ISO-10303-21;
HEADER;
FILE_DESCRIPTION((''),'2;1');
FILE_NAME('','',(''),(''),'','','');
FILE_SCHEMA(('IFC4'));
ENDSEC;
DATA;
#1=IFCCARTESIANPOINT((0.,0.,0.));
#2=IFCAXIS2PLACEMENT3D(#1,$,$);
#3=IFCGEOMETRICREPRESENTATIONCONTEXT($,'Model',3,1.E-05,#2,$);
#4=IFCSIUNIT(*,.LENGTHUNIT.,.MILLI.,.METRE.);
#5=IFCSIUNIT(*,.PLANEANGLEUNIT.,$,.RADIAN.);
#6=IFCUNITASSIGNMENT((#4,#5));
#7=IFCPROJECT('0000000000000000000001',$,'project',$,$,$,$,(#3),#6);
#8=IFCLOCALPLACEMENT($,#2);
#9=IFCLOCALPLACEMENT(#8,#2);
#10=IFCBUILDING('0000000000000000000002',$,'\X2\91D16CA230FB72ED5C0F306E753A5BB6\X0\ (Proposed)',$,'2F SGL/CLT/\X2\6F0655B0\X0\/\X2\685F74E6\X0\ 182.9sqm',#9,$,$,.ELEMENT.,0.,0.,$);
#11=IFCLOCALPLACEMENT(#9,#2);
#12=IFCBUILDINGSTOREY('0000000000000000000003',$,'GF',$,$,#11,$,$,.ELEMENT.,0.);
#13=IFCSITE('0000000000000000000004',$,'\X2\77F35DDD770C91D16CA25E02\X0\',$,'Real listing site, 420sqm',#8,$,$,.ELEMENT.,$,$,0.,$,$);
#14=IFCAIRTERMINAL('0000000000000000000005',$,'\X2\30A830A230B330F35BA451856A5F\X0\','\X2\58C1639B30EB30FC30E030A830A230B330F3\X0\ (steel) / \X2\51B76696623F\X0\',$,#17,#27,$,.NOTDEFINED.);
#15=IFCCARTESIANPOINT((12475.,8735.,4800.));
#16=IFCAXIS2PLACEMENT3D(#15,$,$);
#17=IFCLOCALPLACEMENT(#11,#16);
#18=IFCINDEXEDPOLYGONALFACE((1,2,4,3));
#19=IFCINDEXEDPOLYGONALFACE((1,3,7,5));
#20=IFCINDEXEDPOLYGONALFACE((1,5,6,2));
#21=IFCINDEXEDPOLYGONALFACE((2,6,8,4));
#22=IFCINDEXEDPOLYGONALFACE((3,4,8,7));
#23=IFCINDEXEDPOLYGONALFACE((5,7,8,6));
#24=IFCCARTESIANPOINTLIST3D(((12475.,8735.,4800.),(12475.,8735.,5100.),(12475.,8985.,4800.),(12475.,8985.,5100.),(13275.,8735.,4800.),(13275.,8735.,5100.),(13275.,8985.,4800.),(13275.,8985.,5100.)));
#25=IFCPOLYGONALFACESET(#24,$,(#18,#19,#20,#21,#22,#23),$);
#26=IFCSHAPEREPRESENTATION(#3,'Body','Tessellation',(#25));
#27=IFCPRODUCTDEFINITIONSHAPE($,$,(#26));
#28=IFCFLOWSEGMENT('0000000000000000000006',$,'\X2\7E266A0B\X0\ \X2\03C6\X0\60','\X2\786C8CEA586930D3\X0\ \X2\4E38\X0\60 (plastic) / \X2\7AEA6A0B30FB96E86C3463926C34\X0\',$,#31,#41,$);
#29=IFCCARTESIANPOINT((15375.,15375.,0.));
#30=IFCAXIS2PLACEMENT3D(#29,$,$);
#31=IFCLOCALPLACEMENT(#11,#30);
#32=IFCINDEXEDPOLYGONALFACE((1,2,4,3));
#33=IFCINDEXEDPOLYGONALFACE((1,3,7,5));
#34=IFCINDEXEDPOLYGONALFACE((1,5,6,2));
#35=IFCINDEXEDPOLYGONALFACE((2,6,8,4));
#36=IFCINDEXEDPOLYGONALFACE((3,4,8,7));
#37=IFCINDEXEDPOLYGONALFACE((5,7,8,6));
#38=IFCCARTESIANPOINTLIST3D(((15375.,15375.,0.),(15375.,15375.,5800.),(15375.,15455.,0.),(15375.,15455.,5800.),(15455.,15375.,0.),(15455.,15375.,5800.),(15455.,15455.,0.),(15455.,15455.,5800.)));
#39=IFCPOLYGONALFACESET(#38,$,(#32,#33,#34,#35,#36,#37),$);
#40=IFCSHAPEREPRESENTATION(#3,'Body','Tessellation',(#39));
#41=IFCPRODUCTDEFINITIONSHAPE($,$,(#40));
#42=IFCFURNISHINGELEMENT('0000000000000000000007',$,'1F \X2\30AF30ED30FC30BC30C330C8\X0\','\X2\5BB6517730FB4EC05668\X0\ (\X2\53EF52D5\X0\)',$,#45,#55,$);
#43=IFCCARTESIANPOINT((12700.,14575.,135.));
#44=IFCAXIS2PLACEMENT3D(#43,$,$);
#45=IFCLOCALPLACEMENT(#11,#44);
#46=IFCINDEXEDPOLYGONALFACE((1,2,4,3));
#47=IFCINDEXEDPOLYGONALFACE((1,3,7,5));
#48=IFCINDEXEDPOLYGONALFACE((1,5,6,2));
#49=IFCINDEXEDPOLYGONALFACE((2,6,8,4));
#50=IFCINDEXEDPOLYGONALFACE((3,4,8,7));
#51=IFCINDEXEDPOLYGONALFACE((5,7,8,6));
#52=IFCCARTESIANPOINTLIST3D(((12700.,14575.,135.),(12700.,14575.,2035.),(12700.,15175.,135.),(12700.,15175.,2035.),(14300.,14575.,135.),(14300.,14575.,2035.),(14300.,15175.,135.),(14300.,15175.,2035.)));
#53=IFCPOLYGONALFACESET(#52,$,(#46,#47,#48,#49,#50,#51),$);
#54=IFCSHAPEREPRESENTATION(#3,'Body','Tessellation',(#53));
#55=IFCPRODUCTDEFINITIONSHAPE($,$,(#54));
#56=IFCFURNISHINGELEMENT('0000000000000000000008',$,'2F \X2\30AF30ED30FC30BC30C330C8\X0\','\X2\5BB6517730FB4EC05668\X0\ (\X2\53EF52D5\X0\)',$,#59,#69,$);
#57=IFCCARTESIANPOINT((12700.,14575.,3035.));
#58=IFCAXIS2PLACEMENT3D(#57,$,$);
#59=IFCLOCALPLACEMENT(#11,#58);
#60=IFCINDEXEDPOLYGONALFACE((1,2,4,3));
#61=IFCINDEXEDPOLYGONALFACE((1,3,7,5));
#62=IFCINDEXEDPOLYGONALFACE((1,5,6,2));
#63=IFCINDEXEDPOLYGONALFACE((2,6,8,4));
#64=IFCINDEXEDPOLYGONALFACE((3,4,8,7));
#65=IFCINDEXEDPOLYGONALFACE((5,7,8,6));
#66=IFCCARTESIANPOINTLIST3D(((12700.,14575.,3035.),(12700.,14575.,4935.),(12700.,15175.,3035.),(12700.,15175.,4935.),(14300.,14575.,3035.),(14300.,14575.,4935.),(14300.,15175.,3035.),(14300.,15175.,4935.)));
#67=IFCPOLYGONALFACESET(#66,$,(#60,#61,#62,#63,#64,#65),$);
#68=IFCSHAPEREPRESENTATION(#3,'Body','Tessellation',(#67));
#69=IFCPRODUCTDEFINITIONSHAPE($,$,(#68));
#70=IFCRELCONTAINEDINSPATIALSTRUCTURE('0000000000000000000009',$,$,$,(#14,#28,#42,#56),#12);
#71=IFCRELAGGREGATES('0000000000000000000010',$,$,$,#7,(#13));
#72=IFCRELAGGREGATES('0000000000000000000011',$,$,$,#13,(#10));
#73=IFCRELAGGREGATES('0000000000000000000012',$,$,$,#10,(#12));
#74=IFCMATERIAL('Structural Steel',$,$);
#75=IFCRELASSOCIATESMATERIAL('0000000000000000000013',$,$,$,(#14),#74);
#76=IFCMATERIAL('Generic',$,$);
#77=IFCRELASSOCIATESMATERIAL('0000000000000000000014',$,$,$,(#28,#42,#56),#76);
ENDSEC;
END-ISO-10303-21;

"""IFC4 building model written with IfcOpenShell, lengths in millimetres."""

from ifc_helpers import new_model, si_unit, frame, frame_2d, origin, place, context, project, spatial, rectangle, extrude, material, element, save


model = new_model("IFC4")

# Units and contexts
model_context = context("Model", 3, precision=1e-05, world=origin())
ifc_project = project(units=[si_unit("LENGTHUNIT", "METRE", prefix="MILLI"), si_unit("PLANEANGLEUNIT", "RADIAN")], contexts=[model_context])

# Site, building, storey
site_placement = place(None, origin())
site = spatial("IfcSite", under=ifc_project, at=site_placement, Name="石川県金沢市", ObjectType="Real listing site, 420sqm", CompositionType="ELEMENT", RefElevation=0.0)
building_placement = place(site_placement, origin())
building = spatial("IfcBuilding", under=site, at=building_placement, Name="金沢・狭小の町家 (Proposed)", ObjectType="2F SGL/CLT/漆喰/桟瓦 182.9sqm", CompositionType="ELEMENT", ElevationOfRefHeight=0.0, ElevationOfTerrain=0.0)
storey_placement = place(building_placement, origin())
storey = spatial("IfcBuildingStorey", under=building, at=storey_placement, Name="GF", CompositionType="ELEMENT", Elevation=0.0)

# Shared definitions
ifc_material_1 = material(Name="Generic")

# Air terminal
ifc_material_2 = material(Name="Structural Steel")
air_terminal_placement = place(storey_placement, frame((12475.0, 8735.0, 4800.0)))
element("IfcAirTerminal", 1, at=air_terminal_placement, inside=storey, material=ifc_material_2, Name="エアコン室内機", Description="壁掛ルームエアコン (steel) / 冷暖房", PredefinedType="NOTDEFINED", context=model_context, shape_type="SweptSolid", body=[
    extrude(rectangle(XDim=800.0, YDim=250.0, at=frame_2d((400.0, 125.0))), frame((12475.0, 8735.0, 4800.0)), (0.0, 0.0, 1.0), 300.0),
])

# Flow segment
flow_segment_placement = place(storey_placement, frame((15375.0, 15375.0, 0.0)))
element("IfcFlowSegment", 2, at=flow_segment_placement, inside=storey, material=ifc_material_1, Name="縦樋 φ60", Description="硬質塩ビ 丸60 (plastic) / 竪樋・雨水排水", context=model_context, shape_type="SweptSolid", body=[
    extrude(rectangle(XDim=80.0, YDim=80.0, at=frame_2d((40.0, 40.0))), frame((15375.0, 15375.0, 0.0)), (0.0, 0.0, 1.0), 5800.0),
])

# Furnishing elements
furnishing_1_placement = place(storey_placement, frame((12700.0, 14575.0, 135.0)))
element("IfcFurnishingElement", 3, at=furnishing_1_placement, inside=storey, material=ifc_material_1, Name="1F クローゼット", Description="家具・什器 (可動)", context=model_context, shape_type="SweptSolid", body=[
    extrude(rectangle(XDim=1600.0, YDim=600.0, at=frame_2d((800.0, 300.0))), frame((12700.0, 14575.0, 135.0)), (0.0, 0.0, 1.0), 1900.0),
])
furnishing_2_placement = place(storey_placement, frame((12700.0, 14575.0, 3035.0)))
element("IfcFurnishingElement", 4, at=furnishing_2_placement, inside=storey, material=ifc_material_1, Name="2F クローゼット", Description="家具・什器 (可動)", context=model_context, shape_type="SweptSolid", body=[
    extrude(rectangle(XDim=1600.0, YDim=600.0, at=frame_2d((800.0, 300.0))), frame((12700.0, 14575.0, 3035.0)), (0.0, 0.0, 1.0), 1900.0),
])

save(model, "model.ifc")
